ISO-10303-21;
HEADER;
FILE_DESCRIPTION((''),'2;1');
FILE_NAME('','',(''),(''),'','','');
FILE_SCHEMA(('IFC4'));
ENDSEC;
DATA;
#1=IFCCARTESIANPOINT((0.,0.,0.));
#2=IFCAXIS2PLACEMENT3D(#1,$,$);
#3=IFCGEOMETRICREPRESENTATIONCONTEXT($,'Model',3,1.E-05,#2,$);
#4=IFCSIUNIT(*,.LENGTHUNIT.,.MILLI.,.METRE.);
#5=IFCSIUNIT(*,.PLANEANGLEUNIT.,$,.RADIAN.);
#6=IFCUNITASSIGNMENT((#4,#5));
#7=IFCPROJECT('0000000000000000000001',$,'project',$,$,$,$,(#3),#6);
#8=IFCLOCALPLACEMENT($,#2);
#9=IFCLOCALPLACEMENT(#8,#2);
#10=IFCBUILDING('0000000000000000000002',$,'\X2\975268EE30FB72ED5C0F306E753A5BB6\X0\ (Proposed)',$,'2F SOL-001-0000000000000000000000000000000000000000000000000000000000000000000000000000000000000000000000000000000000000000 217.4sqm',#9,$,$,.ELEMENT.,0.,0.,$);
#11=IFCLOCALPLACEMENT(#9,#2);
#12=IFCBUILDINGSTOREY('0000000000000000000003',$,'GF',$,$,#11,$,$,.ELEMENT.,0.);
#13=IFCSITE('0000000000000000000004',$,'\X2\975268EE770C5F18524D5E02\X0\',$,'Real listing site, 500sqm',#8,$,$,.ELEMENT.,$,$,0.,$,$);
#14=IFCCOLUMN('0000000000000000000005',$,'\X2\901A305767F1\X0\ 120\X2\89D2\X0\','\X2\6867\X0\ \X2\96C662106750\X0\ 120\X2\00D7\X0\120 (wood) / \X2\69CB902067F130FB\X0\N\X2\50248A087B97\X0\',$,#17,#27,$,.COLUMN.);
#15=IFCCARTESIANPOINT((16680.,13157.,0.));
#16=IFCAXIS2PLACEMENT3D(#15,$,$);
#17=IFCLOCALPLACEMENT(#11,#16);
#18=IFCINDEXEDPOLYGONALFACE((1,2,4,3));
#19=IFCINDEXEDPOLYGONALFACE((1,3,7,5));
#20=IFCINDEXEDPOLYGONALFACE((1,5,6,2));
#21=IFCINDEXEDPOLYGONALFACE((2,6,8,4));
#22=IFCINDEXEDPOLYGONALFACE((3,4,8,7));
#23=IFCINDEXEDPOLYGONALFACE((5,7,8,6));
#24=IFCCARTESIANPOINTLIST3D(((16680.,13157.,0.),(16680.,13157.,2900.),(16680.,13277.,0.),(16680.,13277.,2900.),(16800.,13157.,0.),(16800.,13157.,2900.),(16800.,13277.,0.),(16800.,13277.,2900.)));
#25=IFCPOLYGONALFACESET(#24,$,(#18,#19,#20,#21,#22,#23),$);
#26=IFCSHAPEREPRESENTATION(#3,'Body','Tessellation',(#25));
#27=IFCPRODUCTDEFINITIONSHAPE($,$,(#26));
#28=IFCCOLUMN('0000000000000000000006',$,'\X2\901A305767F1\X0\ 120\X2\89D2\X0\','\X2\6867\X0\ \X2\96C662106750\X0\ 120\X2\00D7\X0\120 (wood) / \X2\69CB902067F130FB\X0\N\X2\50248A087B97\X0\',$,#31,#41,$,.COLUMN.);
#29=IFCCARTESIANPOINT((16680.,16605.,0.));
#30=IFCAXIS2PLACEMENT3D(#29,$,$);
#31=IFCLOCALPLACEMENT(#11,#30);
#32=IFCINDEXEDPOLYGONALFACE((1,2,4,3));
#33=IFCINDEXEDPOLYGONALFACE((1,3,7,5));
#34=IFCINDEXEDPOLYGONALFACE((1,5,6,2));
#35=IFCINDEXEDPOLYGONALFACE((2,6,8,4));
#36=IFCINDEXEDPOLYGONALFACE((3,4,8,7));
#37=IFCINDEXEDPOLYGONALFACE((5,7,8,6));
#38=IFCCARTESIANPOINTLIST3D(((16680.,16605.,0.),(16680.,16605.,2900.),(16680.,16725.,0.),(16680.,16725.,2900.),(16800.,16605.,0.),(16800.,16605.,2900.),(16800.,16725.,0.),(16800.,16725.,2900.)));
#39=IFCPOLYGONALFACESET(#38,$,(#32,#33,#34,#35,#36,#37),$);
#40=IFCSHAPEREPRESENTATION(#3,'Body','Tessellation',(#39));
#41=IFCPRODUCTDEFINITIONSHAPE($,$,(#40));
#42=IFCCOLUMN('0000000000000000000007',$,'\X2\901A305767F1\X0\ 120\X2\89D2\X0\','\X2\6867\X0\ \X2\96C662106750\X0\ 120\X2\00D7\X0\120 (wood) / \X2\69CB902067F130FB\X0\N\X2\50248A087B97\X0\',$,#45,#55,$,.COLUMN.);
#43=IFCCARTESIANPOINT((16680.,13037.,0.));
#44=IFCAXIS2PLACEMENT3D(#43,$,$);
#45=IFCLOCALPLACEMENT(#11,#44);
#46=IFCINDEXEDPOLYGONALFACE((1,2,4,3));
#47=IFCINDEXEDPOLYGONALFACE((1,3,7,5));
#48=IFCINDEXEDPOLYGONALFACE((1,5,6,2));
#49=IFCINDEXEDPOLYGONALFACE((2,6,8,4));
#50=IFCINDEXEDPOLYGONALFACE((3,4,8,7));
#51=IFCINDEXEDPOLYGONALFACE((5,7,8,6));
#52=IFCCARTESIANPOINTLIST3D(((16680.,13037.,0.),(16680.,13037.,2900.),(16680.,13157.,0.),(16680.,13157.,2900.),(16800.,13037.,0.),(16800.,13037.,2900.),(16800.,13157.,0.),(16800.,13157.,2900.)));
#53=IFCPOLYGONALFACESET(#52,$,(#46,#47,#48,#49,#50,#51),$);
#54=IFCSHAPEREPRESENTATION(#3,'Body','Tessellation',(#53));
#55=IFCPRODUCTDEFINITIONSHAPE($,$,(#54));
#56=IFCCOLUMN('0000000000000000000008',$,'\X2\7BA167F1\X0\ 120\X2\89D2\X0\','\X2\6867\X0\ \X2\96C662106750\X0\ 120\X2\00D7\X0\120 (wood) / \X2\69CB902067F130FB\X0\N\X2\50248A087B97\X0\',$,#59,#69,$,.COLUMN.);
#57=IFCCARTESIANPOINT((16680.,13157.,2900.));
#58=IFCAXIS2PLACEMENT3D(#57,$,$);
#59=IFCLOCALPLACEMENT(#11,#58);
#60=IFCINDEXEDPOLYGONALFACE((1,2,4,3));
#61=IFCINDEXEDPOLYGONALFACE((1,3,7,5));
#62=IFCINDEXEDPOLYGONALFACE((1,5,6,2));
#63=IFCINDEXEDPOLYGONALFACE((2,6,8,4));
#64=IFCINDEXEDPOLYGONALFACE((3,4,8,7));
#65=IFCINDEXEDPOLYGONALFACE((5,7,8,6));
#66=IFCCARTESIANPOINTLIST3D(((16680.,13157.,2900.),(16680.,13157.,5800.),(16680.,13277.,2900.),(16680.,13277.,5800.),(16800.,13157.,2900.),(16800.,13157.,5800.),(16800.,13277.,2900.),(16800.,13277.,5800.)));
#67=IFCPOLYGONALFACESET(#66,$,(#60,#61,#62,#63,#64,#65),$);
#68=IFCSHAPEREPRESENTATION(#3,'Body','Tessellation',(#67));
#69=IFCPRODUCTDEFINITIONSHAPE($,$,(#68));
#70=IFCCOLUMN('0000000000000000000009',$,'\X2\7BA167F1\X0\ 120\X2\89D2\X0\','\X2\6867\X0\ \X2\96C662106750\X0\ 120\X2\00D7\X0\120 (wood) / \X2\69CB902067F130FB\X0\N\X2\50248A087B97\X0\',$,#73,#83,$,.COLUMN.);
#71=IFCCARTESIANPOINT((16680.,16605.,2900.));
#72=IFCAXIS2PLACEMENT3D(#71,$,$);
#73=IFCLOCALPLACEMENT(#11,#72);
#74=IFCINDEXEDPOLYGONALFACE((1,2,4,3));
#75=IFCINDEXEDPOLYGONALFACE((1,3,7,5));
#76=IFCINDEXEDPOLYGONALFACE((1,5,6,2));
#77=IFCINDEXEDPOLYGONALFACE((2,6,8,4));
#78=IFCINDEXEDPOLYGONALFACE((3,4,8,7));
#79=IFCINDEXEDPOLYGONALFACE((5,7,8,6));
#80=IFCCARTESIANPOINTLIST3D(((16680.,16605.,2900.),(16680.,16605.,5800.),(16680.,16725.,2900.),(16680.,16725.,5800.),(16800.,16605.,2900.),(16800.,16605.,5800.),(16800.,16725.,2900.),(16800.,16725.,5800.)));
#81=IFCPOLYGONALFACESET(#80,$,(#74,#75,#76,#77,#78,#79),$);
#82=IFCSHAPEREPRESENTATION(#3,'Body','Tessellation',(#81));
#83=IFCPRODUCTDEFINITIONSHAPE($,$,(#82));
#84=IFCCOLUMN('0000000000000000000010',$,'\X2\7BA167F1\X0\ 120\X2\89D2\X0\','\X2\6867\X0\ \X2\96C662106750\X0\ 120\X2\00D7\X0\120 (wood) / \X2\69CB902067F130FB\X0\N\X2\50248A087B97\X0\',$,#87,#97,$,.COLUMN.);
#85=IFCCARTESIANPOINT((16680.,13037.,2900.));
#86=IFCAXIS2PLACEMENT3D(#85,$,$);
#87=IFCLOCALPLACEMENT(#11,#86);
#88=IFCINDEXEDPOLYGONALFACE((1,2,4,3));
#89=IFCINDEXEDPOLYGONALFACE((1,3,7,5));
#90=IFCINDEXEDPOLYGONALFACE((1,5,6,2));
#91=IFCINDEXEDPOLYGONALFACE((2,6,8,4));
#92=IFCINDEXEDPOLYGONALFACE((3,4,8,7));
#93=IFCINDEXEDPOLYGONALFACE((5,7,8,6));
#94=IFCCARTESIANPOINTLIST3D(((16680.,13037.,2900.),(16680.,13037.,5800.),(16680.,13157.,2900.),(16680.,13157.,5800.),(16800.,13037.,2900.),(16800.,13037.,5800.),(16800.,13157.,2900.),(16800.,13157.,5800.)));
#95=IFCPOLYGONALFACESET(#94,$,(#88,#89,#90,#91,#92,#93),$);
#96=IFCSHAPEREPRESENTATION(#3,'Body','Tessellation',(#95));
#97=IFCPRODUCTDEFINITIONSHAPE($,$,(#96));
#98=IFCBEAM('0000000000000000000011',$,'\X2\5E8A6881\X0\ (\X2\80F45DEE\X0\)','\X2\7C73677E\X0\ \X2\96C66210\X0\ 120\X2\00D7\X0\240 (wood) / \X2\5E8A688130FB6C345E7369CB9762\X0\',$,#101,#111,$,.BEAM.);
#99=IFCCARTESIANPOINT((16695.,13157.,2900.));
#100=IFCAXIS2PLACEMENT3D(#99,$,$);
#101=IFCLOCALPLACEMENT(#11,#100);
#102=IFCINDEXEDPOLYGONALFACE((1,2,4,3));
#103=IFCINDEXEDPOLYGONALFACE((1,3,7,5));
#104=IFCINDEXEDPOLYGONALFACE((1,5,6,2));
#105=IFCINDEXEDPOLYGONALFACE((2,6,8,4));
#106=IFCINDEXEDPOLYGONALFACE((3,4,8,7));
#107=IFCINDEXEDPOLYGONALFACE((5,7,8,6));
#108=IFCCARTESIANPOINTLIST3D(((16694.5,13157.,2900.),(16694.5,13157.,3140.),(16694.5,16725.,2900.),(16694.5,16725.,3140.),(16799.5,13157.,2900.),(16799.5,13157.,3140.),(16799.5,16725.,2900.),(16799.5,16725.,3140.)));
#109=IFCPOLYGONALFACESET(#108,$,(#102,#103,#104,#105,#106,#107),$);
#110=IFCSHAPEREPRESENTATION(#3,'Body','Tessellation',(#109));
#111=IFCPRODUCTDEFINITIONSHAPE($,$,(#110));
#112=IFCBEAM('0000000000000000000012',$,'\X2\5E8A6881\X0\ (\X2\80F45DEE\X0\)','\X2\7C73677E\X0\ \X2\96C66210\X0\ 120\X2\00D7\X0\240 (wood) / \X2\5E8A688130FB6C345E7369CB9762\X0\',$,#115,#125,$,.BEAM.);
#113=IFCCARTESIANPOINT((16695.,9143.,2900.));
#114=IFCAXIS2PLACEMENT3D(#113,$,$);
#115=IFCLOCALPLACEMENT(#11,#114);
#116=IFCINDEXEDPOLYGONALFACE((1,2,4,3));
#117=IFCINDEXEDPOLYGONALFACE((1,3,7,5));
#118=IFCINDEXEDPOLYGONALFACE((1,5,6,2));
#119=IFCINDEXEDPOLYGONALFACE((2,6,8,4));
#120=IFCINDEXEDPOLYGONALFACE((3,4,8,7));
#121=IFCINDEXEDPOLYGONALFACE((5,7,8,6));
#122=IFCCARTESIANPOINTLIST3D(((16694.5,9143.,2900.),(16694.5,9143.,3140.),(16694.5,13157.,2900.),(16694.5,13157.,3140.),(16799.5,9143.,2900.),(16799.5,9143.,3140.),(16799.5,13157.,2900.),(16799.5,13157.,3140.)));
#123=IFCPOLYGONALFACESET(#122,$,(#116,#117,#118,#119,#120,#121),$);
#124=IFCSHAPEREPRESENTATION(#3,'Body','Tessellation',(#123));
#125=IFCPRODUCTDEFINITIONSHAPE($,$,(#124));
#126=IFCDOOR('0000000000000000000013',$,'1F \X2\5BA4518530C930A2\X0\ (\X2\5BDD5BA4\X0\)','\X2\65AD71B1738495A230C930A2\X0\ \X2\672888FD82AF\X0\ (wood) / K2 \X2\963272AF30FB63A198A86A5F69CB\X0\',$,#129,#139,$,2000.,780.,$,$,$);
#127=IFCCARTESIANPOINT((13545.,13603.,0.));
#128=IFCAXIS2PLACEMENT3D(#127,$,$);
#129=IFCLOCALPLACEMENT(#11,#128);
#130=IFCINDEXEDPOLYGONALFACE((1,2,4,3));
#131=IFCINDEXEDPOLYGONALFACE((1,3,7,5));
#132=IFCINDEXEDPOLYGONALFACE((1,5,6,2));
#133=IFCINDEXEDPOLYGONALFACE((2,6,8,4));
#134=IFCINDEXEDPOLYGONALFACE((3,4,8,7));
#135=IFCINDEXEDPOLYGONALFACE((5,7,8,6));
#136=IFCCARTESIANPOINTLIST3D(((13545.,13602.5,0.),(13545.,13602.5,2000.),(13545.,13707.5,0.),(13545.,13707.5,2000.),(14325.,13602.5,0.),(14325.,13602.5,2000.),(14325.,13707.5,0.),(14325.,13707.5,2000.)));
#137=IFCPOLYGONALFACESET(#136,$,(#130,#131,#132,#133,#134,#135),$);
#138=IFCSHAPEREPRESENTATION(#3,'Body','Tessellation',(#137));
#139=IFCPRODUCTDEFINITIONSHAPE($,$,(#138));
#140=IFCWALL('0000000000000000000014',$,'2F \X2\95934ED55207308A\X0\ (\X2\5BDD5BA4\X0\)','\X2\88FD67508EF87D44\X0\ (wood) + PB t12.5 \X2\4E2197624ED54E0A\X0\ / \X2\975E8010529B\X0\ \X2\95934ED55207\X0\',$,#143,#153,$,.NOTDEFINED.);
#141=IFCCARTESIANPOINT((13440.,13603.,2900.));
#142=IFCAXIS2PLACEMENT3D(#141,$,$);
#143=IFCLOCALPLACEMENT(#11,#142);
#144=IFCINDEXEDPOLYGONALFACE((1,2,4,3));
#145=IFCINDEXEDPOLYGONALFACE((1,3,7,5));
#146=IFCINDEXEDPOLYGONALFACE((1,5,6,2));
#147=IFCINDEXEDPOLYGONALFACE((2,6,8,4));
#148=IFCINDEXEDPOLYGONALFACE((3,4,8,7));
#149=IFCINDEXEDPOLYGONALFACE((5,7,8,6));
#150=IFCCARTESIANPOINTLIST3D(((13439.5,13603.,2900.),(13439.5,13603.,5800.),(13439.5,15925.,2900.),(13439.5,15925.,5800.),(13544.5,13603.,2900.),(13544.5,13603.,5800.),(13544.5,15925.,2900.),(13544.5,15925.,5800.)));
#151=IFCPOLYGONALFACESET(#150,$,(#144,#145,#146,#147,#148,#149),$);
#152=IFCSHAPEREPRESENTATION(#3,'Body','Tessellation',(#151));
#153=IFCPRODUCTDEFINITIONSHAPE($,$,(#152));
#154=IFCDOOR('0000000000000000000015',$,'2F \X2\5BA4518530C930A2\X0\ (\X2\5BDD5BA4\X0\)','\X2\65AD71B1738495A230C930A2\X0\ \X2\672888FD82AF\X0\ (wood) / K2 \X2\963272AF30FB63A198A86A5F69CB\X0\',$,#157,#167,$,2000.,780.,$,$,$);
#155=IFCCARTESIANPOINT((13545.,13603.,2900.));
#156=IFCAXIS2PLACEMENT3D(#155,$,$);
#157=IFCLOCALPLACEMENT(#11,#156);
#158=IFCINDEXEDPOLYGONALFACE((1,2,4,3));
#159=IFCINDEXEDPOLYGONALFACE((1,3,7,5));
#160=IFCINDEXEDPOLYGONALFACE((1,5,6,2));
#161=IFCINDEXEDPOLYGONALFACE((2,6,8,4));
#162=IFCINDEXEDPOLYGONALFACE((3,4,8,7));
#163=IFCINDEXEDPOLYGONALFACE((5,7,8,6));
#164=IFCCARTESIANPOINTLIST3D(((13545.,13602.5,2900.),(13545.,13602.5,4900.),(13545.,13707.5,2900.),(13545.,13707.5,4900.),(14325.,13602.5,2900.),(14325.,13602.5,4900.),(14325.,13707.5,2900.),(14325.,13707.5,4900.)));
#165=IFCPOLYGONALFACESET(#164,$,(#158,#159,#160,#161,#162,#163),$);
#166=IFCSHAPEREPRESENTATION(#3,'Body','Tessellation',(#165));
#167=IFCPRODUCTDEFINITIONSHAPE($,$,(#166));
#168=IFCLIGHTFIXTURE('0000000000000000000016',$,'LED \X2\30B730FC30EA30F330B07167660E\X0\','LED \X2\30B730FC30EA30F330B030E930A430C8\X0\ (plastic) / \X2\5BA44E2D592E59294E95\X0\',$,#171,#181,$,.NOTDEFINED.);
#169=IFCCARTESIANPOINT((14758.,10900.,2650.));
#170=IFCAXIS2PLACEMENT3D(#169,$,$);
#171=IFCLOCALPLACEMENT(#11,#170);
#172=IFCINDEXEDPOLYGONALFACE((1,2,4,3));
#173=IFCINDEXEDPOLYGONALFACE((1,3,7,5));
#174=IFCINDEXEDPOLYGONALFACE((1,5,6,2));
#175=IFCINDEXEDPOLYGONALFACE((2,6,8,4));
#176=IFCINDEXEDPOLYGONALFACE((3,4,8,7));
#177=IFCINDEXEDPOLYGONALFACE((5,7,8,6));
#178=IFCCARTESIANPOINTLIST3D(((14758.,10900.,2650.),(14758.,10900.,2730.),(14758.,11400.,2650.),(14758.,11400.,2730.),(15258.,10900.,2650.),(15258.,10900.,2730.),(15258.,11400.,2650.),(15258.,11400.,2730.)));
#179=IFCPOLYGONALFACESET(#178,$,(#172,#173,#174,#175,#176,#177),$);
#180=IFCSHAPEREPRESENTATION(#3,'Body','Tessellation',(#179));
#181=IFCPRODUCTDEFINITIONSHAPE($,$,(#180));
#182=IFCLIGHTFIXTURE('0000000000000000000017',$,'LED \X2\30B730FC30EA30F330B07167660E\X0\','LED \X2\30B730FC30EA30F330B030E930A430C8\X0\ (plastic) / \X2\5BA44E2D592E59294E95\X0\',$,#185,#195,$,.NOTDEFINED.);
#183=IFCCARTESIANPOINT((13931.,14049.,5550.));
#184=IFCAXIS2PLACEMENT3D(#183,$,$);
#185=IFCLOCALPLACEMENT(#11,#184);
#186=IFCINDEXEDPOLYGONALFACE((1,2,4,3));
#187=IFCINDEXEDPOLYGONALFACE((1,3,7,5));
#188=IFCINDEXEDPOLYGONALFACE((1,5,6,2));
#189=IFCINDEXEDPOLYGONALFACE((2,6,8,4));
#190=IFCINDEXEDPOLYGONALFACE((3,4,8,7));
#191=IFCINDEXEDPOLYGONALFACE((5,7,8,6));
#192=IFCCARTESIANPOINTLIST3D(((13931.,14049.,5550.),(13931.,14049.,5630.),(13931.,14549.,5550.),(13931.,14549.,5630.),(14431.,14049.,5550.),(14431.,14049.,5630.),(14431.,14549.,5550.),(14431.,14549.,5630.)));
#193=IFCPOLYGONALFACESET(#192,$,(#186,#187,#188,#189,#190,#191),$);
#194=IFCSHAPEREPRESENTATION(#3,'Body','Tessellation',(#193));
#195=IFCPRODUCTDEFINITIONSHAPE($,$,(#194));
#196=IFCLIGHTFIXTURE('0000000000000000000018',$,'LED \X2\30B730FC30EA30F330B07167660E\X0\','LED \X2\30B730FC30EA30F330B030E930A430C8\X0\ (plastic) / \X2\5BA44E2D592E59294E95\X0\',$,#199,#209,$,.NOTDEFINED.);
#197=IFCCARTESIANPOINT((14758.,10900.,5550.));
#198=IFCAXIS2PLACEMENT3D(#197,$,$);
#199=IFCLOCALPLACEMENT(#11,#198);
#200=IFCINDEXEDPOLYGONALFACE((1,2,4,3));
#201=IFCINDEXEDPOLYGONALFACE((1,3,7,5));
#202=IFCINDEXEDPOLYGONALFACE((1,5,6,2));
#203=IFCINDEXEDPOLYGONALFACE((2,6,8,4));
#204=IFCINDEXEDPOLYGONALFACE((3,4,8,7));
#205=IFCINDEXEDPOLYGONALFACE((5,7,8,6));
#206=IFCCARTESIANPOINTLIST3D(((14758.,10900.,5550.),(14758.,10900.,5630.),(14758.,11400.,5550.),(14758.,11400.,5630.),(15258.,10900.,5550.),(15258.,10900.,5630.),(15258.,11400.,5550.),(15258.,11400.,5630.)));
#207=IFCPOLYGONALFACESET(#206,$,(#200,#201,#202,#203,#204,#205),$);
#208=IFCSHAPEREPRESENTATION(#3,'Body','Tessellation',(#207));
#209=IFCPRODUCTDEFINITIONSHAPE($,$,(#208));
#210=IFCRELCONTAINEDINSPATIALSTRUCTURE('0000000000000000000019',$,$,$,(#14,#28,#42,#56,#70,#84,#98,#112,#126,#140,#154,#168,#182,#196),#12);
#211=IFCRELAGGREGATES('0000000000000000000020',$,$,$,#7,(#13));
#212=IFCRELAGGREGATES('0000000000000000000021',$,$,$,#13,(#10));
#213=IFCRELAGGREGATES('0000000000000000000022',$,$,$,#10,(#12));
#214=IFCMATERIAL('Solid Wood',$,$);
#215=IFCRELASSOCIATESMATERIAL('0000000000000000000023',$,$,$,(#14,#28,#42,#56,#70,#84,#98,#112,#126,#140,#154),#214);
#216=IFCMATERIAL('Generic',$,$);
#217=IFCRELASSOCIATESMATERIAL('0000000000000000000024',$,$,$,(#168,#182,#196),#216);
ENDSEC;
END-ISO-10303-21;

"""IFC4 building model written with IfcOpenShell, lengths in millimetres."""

from ifc_helpers import new_model, si_unit, frame, frame_2d, origin, place, context, project, spatial, rectangle, extrude, material, element, save


model = new_model("IFC4")

# Units and contexts
model_context = context("Model", 3, precision=1e-05, world=origin())
ifc_project = project(units=[si_unit("LENGTHUNIT", "METRE", prefix="MILLI"), si_unit("PLANEANGLEUNIT", "RADIAN")], contexts=[model_context])

# Site, building, storey
site_placement = place(None, origin())
site = spatial("IfcSite", under=ifc_project, at=site_placement, Name="青森県弘前市", ObjectType="Real listing site, 500sqm", CompositionType="ELEMENT", RefElevation=0.0)
building_placement = place(site_placement, origin())
building = spatial("IfcBuilding", under=site, at=building_placement, Name="青森・狭小の町家 (Proposed)", ObjectType="2F SOL-001-0000000000000000000000000000000000000000000000000000000000000000000000000000000000000000000000000000000000000000 217.4sqm", CompositionType="ELEMENT", ElevationOfRefHeight=0.0, ElevationOfTerrain=0.0)
storey_placement = place(building_placement, origin())
storey = spatial("IfcBuildingStorey", under=building, at=storey_placement, Name="GF", CompositionType="ELEMENT", Elevation=0.0)

# Columns
ifc_material_1 = material(Name="Solid Wood")
column_1_placement = place(storey_placement, frame((16680.0, 13157.0, 0.0)))
element("IfcColumn", 1, at=column_1_placement, inside=storey, material=ifc_material_1, Name="通し柱 120角", Description="桧 集成材 120×120 (wood) / 構造柱・N値計算", PredefinedType="COLUMN", context=model_context, shape_type="SweptSolid", body=[
    extrude(rectangle(XDim=120.0, YDim=120.0, at=frame_2d((60.0, 60.0))), frame((16680.0, 13157.0, 0.0)), (0.0, 0.0, 1.0), 2900.0),
])
column_2_placement = place(storey_placement, frame((16680.0, 16605.0, 0.0)))
element("IfcColumn", 2, at=column_2_placement, inside=storey, material=ifc_material_1, Name="通し柱 120角", Description="桧 集成材 120×120 (wood) / 構造柱・N値計算", PredefinedType="COLUMN", context=model_context, shape_type="SweptSolid", body=[
    extrude(rectangle(XDim=120.0, YDim=120.0, at=frame_2d((60.0, 60.0))), frame((16680.0, 16605.0, 0.0)), (0.0, 0.0, 1.0), 2900.0),
])
column_3_placement = place(storey_placement, frame((16680.0, 13037.0, 0.0)))
element("IfcColumn", 3, at=column_3_placement, inside=storey, material=ifc_material_1, Name="通し柱 120角", Description="桧 集成材 120×120 (wood) / 構造柱・N値計算", PredefinedType="COLUMN", context=model_context, shape_type="SweptSolid", body=[
    extrude(rectangle(XDim=120.0, YDim=120.0, at=frame_2d((60.0, 60.0))), frame((16680.0, 13037.0, 0.0)), (0.0, 0.0, 1.0), 2900.0),
])
column_4_placement = place(storey_placement, frame((16680.0, 13157.0, 2900.0)))
element("IfcColumn", 4, at=column_4_placement, inside=storey, material=ifc_material_1, Name="管柱 120角", Description="桧 集成材 120×120 (wood) / 構造柱・N値計算", PredefinedType="COLUMN", context=model_context, shape_type="SweptSolid", body=[
    extrude(rectangle(XDim=120.0, YDim=120.0, at=frame_2d((60.0, 60.0))), frame((16680.0, 13157.0, 2900.0)), (0.0, 0.0, 1.0), 2900.0),
])
column_5_placement = place(storey_placement, frame((16680.0, 16605.0, 2900.0)))
element("IfcColumn", 5, at=column_5_placement, inside=storey, material=ifc_material_1, Name="管柱 120角", Description="桧 集成材 120×120 (wood) / 構造柱・N値計算", PredefinedType="COLUMN", context=model_context, shape_type="SweptSolid", body=[
    extrude(rectangle(XDim=120.0, YDim=120.0, at=frame_2d((60.0, 60.0))), frame((16680.0, 16605.0, 2900.0)), (0.0, 0.0, 1.0), 2900.0),
])
column_6_placement = place(storey_placement, frame((16680.0, 13037.0, 2900.0)))
element("IfcColumn", 6, at=column_6_placement, inside=storey, material=ifc_material_1, Name="管柱 120角", Description="桧 集成材 120×120 (wood) / 構造柱・N値計算", PredefinedType="COLUMN", context=model_context, shape_type="SweptSolid", body=[
    extrude(rectangle(XDim=120.0, YDim=120.0, at=frame_2d((60.0, 60.0))), frame((16680.0, 13037.0, 2900.0)), (0.0, 0.0, 1.0), 2900.0),
])

# Beams
beam_1_placement = place(storey_placement, frame((16695.0, 13157.0, 2900.0)))
element("IfcBeam", 7, at=beam_1_placement, inside=storey, material=ifc_material_1, Name="床梁 (胴差)", Description="米松 集成 120×240 (wood) / 床梁・水平構面", PredefinedType="BEAM", context=model_context, shape_type="SweptSolid", body=[
    extrude(rectangle(XDim=105.0, YDim=3568.0, at=frame_2d((52.0, 1784.0))), frame((16695.0, 13157.0, 2900.0)), (0.0, 0.0, 1.0), 240.0),
])
beam_2_placement = place(storey_placement, frame((16695.0, 9143.0, 2900.0)))
element("IfcBeam", 8, at=beam_2_placement, inside=storey, material=ifc_material_1, Name="床梁 (胴差)", Description="米松 集成 120×240 (wood) / 床梁・水平構面", PredefinedType="BEAM", context=model_context, shape_type="SweptSolid", body=[
    extrude(rectangle(XDim=105.0, YDim=4014.0, at=frame_2d((52.0, 2007.0))), frame((16695.0, 9143.0, 2900.0)), (0.0, 0.0, 1.0), 240.0),
])

# Door
door_1_placement = place(storey_placement, frame((13545.0, 13603.0, 0.0)))
element("IfcDoor", 9, at=door_1_placement, inside=storey, material=ifc_material_1, Name="1F 室内ドア (寝室)", Description="断熱玄関ドア 木製芯 (wood) / K2 防犯・採風機構", OverallHeight=2000.0, OverallWidth=780.0, context=model_context, shape_type="SweptSolid", body=[
    extrude(rectangle(XDim=780.0, YDim=105.0, at=frame_2d((390.0, 52.0))), frame((13545.0, 13603.0, 0.0)), (0.0, 0.0, 1.0), 2000.0),
])

# Wall
wall_placement = place(storey_placement, frame((13440.0, 13603.0, 2900.0)))
element("IfcWall", 10, at=wall_placement, inside=storey, material=ifc_material_1, Name="2F 間仕切り (寝室)", Description="製材軸組 (wood) + PB t12.5 両面仕上 / 非耐力 間仕切", PredefinedType="NOTDEFINED", context=model_context, shape_type="SweptSolid", body=[
    extrude(rectangle(XDim=105.0, YDim=2322.0, at=frame_2d((52.0, 1161.0))), frame((13440.0, 13603.0, 2900.0)), (0.0, 0.0, 1.0), 2900.0),
])

# Door
door_2_placement = place(storey_placement, frame((13545.0, 13603.0, 2900.0)))
element("IfcDoor", 11, at=door_2_placement, inside=storey, material=ifc_material_1, Name="2F 室内ドア (寝室)", Description="断熱玄関ドア 木製芯 (wood) / K2 防犯・採風機構", OverallHeight=2000.0, OverallWidth=780.0, context=model_context, shape_type="SweptSolid", body=[
    extrude(rectangle(XDim=780.0, YDim=105.0, at=frame_2d((390.0, 52.0))), frame((13545.0, 13603.0, 2900.0)), (0.0, 0.0, 1.0), 2000.0),
])

# Light fixtures
ifc_material_2 = material(Name="Generic")
light_fixture_1_placement = place(storey_placement, frame((14758.0, 10900.0, 2650.0)))
element("IfcLightFixture", 12, at=light_fixture_1_placement, inside=storey, material=ifc_material_2, Name="LED シーリング照明", Description="LED シーリングライト (plastic) / 室中央天井", PredefinedType="NOTDEFINED", context=model_context, shape_type="SweptSolid", body=[
    extrude(rectangle(XDim=500.0, YDim=500.0, at=frame_2d((250.0, 250.0))), frame((14758.0, 10900.0, 2650.0)), (0.0, 0.0, 1.0), 80.0),
])
light_fixture_2_placement = place(storey_placement, frame((13931.0, 14049.0, 5550.0)))
element("IfcLightFixture", 13, at=light_fixture_2_placement, inside=storey, material=ifc_material_2, Name="LED シーリング照明", Description="LED シーリングライト (plastic) / 室中央天井", PredefinedType="NOTDEFINED", context=model_context, shape_type="SweptSolid", body=[
    extrude(rectangle(XDim=500.0, YDim=500.0, at=frame_2d((250.0, 250.0))), frame((13931.0, 14049.0, 5550.0)), (0.0, 0.0, 1.0), 80.0),
])
light_fixture_3_placement = place(storey_placement, frame((14758.0, 10900.0, 5550.0)))
element("IfcLightFixture", 14, at=light_fixture_3_placement, inside=storey, material=ifc_material_2, Name="LED シーリング照明", Description="LED シーリングライト (plastic) / 室中央天井", PredefinedType="NOTDEFINED", context=model_context, shape_type="SweptSolid", body=[
    extrude(rectangle(XDim=500.0, YDim=500.0, at=frame_2d((250.0, 250.0))), frame((14758.0, 10900.0, 5550.0)), (0.0, 0.0, 1.0), 80.0),
])

save(model, "model.ifc")
